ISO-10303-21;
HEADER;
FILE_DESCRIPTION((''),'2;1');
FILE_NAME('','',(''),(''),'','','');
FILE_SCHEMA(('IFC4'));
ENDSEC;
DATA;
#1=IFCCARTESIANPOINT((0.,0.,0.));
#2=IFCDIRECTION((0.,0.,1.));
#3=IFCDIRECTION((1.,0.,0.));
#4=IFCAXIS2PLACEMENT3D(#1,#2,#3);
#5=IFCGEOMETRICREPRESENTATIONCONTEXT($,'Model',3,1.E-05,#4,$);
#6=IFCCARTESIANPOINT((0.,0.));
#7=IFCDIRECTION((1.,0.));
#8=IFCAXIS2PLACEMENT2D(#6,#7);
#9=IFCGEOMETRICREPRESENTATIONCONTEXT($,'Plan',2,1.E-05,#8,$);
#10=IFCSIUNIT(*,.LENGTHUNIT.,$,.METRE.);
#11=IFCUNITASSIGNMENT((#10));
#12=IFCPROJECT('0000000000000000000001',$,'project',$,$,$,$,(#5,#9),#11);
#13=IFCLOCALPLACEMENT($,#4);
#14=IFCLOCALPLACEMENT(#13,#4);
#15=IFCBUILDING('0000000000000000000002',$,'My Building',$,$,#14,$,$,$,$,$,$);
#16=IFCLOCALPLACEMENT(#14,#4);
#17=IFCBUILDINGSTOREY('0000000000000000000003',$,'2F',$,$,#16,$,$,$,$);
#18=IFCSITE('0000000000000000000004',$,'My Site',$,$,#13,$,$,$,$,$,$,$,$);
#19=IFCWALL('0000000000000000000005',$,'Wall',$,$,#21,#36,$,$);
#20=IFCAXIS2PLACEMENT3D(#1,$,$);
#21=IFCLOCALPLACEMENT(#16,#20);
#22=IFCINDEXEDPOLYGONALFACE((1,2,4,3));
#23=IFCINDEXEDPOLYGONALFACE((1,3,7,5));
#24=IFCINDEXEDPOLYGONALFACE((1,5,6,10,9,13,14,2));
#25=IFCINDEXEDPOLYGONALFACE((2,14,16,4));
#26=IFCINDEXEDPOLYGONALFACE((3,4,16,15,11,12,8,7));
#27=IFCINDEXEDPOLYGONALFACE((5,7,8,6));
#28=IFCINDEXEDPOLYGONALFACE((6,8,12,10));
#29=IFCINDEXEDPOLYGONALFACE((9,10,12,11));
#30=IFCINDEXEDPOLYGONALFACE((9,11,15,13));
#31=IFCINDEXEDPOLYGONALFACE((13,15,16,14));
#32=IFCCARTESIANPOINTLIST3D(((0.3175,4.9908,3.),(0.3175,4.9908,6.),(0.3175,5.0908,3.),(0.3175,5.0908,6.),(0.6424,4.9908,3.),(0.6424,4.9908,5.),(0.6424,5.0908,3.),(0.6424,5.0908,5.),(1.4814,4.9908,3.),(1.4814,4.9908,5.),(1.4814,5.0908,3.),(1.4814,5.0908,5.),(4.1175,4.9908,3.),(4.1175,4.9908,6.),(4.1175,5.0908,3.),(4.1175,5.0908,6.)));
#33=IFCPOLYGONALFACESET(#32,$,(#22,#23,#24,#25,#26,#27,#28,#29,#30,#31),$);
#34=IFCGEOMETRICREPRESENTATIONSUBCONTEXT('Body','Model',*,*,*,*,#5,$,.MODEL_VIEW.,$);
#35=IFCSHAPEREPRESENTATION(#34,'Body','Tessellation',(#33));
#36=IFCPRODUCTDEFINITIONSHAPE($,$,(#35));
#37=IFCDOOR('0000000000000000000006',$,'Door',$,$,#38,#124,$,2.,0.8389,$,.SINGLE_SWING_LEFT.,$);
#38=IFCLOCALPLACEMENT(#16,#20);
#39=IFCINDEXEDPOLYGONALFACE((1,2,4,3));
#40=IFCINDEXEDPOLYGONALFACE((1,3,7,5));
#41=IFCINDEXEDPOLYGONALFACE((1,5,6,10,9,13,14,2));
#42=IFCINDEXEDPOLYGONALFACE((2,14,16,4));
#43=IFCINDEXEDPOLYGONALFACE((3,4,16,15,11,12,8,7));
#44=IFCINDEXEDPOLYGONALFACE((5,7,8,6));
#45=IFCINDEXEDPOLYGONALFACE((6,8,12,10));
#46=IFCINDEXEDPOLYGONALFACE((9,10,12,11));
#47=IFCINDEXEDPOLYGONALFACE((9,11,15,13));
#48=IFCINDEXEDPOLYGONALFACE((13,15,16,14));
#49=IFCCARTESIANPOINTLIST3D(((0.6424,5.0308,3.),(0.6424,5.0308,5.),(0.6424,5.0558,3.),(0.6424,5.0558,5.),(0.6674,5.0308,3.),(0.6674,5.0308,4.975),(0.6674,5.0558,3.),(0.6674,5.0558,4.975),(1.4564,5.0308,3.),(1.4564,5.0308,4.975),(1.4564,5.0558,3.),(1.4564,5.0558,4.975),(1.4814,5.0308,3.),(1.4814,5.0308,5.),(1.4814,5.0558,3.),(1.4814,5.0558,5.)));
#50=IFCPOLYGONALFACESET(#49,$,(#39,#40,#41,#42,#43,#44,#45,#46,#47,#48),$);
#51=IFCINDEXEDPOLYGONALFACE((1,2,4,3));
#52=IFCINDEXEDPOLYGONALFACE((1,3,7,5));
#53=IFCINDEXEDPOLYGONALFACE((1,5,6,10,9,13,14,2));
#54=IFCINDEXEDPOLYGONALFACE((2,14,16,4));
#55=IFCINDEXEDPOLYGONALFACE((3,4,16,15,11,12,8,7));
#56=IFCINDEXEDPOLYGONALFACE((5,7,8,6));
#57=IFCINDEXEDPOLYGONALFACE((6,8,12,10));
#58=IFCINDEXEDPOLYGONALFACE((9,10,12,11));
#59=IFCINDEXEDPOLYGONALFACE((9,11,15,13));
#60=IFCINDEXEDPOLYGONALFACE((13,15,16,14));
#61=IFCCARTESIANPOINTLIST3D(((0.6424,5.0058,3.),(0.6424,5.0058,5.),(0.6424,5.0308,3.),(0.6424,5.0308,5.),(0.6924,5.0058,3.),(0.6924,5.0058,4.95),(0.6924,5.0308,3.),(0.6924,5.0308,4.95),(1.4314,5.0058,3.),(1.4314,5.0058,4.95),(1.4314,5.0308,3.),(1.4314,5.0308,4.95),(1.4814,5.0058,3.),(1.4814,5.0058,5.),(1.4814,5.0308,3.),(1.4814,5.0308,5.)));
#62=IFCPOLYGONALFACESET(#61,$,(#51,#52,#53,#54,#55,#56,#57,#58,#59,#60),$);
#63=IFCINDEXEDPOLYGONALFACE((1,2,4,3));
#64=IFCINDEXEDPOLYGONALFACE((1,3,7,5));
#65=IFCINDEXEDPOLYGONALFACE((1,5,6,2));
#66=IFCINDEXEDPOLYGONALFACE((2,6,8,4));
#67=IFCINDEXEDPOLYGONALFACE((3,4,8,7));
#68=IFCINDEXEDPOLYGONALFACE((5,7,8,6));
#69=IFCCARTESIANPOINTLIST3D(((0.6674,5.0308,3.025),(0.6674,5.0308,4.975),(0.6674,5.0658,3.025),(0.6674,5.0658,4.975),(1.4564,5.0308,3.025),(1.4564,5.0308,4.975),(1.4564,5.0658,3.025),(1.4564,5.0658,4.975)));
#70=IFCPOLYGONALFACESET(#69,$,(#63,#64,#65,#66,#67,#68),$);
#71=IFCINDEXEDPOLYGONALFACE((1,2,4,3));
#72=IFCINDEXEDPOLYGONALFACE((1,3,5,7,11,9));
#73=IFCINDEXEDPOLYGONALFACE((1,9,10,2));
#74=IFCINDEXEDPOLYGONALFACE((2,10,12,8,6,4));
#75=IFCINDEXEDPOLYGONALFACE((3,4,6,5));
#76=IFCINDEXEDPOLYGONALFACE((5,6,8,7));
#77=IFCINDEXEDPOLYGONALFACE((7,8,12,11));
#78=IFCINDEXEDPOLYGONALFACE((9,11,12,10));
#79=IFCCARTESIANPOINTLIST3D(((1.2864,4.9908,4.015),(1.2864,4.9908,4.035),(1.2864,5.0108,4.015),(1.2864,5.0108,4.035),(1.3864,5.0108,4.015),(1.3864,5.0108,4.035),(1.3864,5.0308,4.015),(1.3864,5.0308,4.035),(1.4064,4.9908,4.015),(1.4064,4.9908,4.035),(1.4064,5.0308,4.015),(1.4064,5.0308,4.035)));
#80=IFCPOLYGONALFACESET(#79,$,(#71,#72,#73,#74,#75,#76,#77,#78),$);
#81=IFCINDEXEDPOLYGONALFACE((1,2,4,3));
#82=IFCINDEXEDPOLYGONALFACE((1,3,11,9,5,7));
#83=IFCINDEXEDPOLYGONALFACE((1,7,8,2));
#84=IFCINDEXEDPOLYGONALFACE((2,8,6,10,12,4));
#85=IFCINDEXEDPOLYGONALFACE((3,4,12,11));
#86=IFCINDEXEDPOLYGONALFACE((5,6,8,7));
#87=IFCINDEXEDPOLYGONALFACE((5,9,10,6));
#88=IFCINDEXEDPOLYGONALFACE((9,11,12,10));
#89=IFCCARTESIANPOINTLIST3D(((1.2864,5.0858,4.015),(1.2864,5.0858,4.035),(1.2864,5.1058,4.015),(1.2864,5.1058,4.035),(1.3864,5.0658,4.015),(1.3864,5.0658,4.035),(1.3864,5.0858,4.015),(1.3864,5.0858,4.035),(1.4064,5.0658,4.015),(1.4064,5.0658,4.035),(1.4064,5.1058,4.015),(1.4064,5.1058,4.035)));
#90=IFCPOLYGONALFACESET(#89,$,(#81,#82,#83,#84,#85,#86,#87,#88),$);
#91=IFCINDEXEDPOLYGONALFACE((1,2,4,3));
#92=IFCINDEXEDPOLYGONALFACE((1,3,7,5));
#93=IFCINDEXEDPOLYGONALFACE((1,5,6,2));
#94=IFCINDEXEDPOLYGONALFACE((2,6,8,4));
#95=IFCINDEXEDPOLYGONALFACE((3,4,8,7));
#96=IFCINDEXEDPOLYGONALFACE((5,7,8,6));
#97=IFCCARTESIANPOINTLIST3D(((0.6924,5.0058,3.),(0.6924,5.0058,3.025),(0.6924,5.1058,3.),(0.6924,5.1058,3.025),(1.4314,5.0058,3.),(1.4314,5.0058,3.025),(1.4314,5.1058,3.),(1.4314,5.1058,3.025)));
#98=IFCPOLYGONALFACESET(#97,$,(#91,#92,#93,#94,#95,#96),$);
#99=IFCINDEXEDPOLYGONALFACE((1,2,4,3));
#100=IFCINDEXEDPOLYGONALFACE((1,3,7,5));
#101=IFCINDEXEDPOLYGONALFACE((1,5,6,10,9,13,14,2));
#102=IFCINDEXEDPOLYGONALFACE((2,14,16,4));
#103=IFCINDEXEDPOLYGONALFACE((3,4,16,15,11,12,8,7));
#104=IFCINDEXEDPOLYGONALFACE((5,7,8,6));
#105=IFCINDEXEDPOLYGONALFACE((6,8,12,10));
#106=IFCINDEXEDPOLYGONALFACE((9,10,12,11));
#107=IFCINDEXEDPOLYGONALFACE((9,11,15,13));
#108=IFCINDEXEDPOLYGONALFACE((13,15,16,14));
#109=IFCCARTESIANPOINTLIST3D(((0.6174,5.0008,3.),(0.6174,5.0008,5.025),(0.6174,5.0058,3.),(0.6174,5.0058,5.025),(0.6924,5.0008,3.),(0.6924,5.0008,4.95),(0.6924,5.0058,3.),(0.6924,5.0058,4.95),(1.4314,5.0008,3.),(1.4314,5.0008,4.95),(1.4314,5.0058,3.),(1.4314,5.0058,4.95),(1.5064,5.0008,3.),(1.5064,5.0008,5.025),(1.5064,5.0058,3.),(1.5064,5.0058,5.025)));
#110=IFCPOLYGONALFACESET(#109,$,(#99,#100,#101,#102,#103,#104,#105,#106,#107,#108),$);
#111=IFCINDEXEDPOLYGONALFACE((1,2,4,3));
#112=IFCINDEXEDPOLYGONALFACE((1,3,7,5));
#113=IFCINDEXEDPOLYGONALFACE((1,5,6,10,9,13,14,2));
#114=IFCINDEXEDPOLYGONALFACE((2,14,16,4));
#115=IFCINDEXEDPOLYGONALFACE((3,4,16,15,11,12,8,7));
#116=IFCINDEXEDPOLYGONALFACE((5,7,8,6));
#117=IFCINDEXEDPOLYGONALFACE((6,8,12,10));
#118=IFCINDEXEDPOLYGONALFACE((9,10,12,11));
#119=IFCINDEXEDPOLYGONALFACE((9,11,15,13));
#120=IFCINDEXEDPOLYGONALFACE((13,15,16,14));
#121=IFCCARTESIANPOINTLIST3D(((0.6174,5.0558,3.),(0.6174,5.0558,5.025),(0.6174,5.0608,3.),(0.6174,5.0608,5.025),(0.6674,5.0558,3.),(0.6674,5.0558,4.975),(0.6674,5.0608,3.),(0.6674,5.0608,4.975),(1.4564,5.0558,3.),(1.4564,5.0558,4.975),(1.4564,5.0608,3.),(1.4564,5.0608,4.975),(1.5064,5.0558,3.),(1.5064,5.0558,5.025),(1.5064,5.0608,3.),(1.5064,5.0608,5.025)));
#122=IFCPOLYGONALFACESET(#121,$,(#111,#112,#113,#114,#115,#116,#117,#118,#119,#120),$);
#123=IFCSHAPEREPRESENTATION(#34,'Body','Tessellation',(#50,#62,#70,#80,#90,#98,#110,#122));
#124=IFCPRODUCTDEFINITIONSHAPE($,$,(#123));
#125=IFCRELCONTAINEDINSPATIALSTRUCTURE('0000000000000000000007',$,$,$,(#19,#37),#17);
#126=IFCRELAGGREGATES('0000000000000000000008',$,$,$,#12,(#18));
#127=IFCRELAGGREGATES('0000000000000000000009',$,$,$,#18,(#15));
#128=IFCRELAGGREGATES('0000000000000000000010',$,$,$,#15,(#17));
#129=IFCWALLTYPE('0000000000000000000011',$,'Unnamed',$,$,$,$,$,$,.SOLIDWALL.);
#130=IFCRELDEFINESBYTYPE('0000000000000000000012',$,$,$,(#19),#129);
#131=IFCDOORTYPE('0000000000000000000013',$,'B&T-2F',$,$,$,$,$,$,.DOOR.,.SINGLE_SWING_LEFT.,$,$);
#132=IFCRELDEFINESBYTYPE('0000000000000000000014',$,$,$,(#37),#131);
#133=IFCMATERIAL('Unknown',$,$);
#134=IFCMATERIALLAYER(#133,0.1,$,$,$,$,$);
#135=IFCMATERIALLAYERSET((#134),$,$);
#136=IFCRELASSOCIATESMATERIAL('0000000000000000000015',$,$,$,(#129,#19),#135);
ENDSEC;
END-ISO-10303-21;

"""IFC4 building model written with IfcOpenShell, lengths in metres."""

from ifc_helpers import new_model, entity, si_unit, frame, origin_with_axes, origin_2d_with_axis, place, context, subcontext, project, spatial, line, indexed_curve, outline, extrude, shape, source, transform, mapped, material, layer, layer_set, layer_usage, type_object, type_shapes, element, fill, save


model = new_model("IFC4")

# Units and contexts
model_context = context("Model", 3, precision=1e-05, world=origin_with_axes())
plan_context = context("Plan", 2, precision=1e-05, world=origin_2d_with_axis())
body_context_1 = subcontext(model_context, "Body", "Model", "MODEL_VIEW")
body_context_2 = subcontext(plan_context, "Body", "Plan", "PLAN_VIEW")
ifc_project = project(units=[si_unit("LENGTHUNIT", "METRE")], contexts=[model_context, plan_context])

# Site, building, storey
site_placement = place(None, origin_with_axes())
site = spatial("IfcSite", under=ifc_project, at=site_placement, Name="My Site")
building_placement = place(site_placement, origin_with_axes())
building = spatial("IfcBuilding", under=site, at=building_placement, Name="My Building")
storey_placement = place(building_placement, origin_with_axes())
storey = spatial("IfcBuildingStorey", under=building, at=storey_placement, Name="2F")

# Shared definitions
ifc_material = material(Name="Unknown")

# Shared definitions
ifc_layer = layer(ifc_material, 0.1)
ifc_layer_set = layer_set([ifc_layer])
wall_type = type_object("IfcWallType", Name="Unnamed", PredefinedType="SOLIDWALL", material=ifc_layer_set)

# Wall, opening, door
ifc_layer_usage_1 = layer_usage(ifc_layer_set, "AXIS2", "POSITIVE", 0.0)
wall_1_placement = place(storey_placement, frame((4.1175, 5.0908, 3.0), z_axis=(0.0, 0.0, 1.0), x_axis=(-1.0, 0.0, 0.0)))
wall_1 = element("IfcWall", 1, at=wall_1_placement, inside=storey, type_object=wall_type, material=ifc_layer_usage_1, Name="Wall", context=body_context_1, shape_type="SweptSolid", body=[
    extrude(outline(indexed_curve([(0.0, 0.0), (0.0, 0.1), (3.8, 0.1), (3.8, 0.0)], segments=[line(1, 2, 3, 4, 1)])), origin_with_axes(), (0.0, 0.0, 1.0), 3.0),
])
shared_shape_1 = source(origin_with_axes(), body_context_1, "Body", "SweptSolid", [
    extrude(outline(indexed_curve([(0.0, 0.0), (0.8389, 0.0), (0.8389, 2.0), (0.0, 2.0)], segments=[line(1, 2, 3, 4, 1)])), frame((0.0, -0.6, 0.0), z_axis=(0.0, -1.0, 0.0), x_axis=(1.0, 0.0, 0.0)), (0.0, 0.0, -1.0), 1.2),
])
opening_1_placement = place(wall_1_placement, frame((3.4751, 0.085, 0.0), z_axis=(0.0, 0.0, 1.0), x_axis=(-1.0, 0.0, 0.0)))
opening_1 = element("IfcOpeningElement", 2, at=opening_1_placement, cuts=wall_1, PredefinedType="OPENING", context=body_context_1, shape_type="MappedRepresentation", body=[
    mapped(shared_shape_1, transform((0.0, 0.0, 0.0), x_axis=(1.0, 0.0, 0.0), y_axis=(0.0, 1.0, 0.0), z_axis=(0.0, 0.0, 1.0), scale=1.0)),
])
door_type_1 = type_object("IfcDoorType", Name="B&T-2F", OperationType="SINGLE_SWING_LEFT", PredefinedType="DOOR")
shared_shape_2 = source(origin_with_axes(), body_context_1, "Body", "SweptSolid", [
    extrude(outline(indexed_curve([(0.0, 0.0), (0.0, 2.0), (0.8389, 2.0), (0.8389, 0.0), (0.8139, 0.0), (0.8139, 1.975), (0.025, 1.975), (0.025, 0.0)], segments=[line(1, 2, 3, 4, 5, 6, 7, 8, 1)])), frame((0.0, 0.025, 0.0), z_axis=(0.0, -1.0, 0.0), x_axis=(1.0, 0.0, 0.0)), (0.0, 0.0, -1.0), 0.025),
    extrude(outline(indexed_curve([(0.0, 0.0), (0.0, 2.0), (0.8389, 2.0), (0.8389, 0.0), (0.7889, 0.0), (0.7889, 1.95), (0.05, 1.95), (0.05, 0.0)], segments=[line(1, 2, 3, 4, 5, 6, 7, 8, 1)])), frame((0.0, 0.0, 0.0), z_axis=(0.0, -1.0, 0.0), x_axis=(1.0, 0.0, 0.0)), (0.0, 0.0, -1.0), 0.025),
    extrude(outline(indexed_curve([(0.0, 0.0), (0.7889, 0.0), (0.7889, 0.035), (0.0, 0.035)], segments=[line(1, 2, 3, 4, 1)])), frame((0.025, 0.025, 0.025), z_axis=(0.0, 0.0, 1.0), x_axis=(1.0, 0.0, 0.0)), (0.0, 0.0, 1.0), 1.95),
    extrude(outline(indexed_curve([(0.0, 0.0), (0.0, -0.04), (-0.12, -0.04), (-0.12, -0.02), (-0.02, -0.02), (-0.02, 0.0)], segments=[line(1, 2, 3, 4, 5, 6, 1)])), frame((0.7639, 0.025, 1.015), z_axis=(0.0, 0.0, 1.0), x_axis=(1.0, 0.0, 0.0)), (0.0, 0.0, 1.0), 0.02),
    extrude(outline(indexed_curve([(0.0, 0.0), (0.0, 0.04), (-0.12, 0.04), (-0.12, 0.02), (-0.02, 0.02), (-0.02, 0.0)], segments=[line(1, 2, 3, 4, 5, 6, 1)])), frame((0.7639, 0.06, 1.015), z_axis=(0.0, 0.0, 1.0), x_axis=(1.0, 0.0, 0.0)), (0.0, 0.0, 1.0), 0.02),
    extrude(outline(indexed_curve([(0.0, 0.0), (0.7389, 0.0), (0.7389, 0.1), (0.0, 0.1)], segments=[line(1, 2, 3, 4, 1)])), frame((0.05, 0.0, 0.0), z_axis=(0.0, 0.0, 1.0), x_axis=(1.0, 0.0, 0.0)), (0.0, 0.0, 1.0), 0.025),
    extrude(outline(indexed_curve([(0.0, 0.0), (0.0, 2.025), (0.8889, 2.025), (0.8889, 0.0), (0.8139, 0.0), (0.8139, 1.95), (0.075, 1.95), (0.075, 0.0)], segments=[line(1, 2, 3, 4, 5, 6, 7, 8, 1)])), frame((-0.025, -0.005, 0.0), z_axis=(0.0, -1.0, 0.0), x_axis=(1.0, 0.0, 0.0)), (0.0, 0.0, -1.0), 0.005),
    extrude(outline(indexed_curve([(0.0, 0.0), (0.0, 2.025), (0.8889, 2.025), (0.8889, 0.0), (0.8389, 0.0), (0.8389, 1.975), (0.05, 1.975), (0.05, 0.0)], segments=[line(1, 2, 3, 4, 5, 6, 7, 8, 1)])), frame((-0.025, 0.05, 0.0), z_axis=(0.0, -1.0, 0.0), x_axis=(1.0, 0.0, 0.0)), (0.0, 0.0, -1.0), 0.005),
])
shared_shape_3 = source(origin_with_axes(), body_context_2, "Body", "Curve2D", [
    entity("IfcIndexedPolyCurve", entity("IfcCartesianPointList2D", [[0.0, 0.0], [0.0, 0.05], [0.025, 0.05], [0.025, 0.025], [0.05, 0.025], [0.05, 0.0]]), [entity("IfcLineIndex", [1, 2, 3, 4, 5, 6, 1])]),
    entity("IfcIndexedPolyCurve", entity("IfcCartesianPointList2D", [[0.8389, 0.0], [0.8389, 0.05], [0.8139, 0.05], [0.8139, 0.025], [0.7889, 0.025], [0.7889, 0.0]]), [entity("IfcLineIndex", [1, 2, 3, 4, 5, 6, 1])]),
    entity("IfcTrimmedCurve", entity("IfcEllipse", entity("IfcAxis2Placement2D", entity("IfcCartesianPoint", [0.06, 0.05]), entity("IfcDirection", [1.0, 0.0])), 0.7539, 0.7889), [entity("IfcCartesianPoint", [0.8139, 0.05])], [entity("IfcCartesianPoint", [0.06, 0.8389])], True, "CARTESIAN"),
    entity("IfcIndexedPolyCurve", entity("IfcCartesianPointList2D", [[0.025, 0.05], [0.06, 0.05], [0.06, 0.8389], [0.025, 0.8389]]), [entity("IfcLineIndex", [1, 2, 3, 4, 1])]),
])
type_shapes(door_type_1, [shared_shape_2, shared_shape_3])
door_1_placement = place(opening_1_placement, frame((0.0, 0.0, 0.0), z_axis=(0.0, 0.0, 1.0), x_axis=(1.0, 0.0, 0.0)))
door_1 = element("IfcDoor", 3, at=door_1_placement, inside=storey, type_object=door_type_1, Name="Door", OperationType="SINGLE_SWING_LEFT", OverallHeight=2.0, OverallWidth=0.8389, shapes=[
    shape(body_context_1, "Body", "MappedRepresentation", [mapped(shared_shape_2, transform((0.0, 0.0, 0.0), x_axis=(1.0, 0.0, 0.0), y_axis=(0.0, 1.0, 0.0), z_axis=(0.0, 0.0, 1.0), scale=1.0))]),
    shape(body_context_2, "Body", "MappedRepresentation", [mapped(shared_shape_3, transform((0.0, 0.0, 0.0), x_axis=(1.0, 0.0, 0.0), y_axis=(0.0, 1.0, 0.0), z_axis=(0.0, 0.0, 1.0), scale=1.0))]),
])
fill(opening_1, door_1)

save(model, "model.ifc")
